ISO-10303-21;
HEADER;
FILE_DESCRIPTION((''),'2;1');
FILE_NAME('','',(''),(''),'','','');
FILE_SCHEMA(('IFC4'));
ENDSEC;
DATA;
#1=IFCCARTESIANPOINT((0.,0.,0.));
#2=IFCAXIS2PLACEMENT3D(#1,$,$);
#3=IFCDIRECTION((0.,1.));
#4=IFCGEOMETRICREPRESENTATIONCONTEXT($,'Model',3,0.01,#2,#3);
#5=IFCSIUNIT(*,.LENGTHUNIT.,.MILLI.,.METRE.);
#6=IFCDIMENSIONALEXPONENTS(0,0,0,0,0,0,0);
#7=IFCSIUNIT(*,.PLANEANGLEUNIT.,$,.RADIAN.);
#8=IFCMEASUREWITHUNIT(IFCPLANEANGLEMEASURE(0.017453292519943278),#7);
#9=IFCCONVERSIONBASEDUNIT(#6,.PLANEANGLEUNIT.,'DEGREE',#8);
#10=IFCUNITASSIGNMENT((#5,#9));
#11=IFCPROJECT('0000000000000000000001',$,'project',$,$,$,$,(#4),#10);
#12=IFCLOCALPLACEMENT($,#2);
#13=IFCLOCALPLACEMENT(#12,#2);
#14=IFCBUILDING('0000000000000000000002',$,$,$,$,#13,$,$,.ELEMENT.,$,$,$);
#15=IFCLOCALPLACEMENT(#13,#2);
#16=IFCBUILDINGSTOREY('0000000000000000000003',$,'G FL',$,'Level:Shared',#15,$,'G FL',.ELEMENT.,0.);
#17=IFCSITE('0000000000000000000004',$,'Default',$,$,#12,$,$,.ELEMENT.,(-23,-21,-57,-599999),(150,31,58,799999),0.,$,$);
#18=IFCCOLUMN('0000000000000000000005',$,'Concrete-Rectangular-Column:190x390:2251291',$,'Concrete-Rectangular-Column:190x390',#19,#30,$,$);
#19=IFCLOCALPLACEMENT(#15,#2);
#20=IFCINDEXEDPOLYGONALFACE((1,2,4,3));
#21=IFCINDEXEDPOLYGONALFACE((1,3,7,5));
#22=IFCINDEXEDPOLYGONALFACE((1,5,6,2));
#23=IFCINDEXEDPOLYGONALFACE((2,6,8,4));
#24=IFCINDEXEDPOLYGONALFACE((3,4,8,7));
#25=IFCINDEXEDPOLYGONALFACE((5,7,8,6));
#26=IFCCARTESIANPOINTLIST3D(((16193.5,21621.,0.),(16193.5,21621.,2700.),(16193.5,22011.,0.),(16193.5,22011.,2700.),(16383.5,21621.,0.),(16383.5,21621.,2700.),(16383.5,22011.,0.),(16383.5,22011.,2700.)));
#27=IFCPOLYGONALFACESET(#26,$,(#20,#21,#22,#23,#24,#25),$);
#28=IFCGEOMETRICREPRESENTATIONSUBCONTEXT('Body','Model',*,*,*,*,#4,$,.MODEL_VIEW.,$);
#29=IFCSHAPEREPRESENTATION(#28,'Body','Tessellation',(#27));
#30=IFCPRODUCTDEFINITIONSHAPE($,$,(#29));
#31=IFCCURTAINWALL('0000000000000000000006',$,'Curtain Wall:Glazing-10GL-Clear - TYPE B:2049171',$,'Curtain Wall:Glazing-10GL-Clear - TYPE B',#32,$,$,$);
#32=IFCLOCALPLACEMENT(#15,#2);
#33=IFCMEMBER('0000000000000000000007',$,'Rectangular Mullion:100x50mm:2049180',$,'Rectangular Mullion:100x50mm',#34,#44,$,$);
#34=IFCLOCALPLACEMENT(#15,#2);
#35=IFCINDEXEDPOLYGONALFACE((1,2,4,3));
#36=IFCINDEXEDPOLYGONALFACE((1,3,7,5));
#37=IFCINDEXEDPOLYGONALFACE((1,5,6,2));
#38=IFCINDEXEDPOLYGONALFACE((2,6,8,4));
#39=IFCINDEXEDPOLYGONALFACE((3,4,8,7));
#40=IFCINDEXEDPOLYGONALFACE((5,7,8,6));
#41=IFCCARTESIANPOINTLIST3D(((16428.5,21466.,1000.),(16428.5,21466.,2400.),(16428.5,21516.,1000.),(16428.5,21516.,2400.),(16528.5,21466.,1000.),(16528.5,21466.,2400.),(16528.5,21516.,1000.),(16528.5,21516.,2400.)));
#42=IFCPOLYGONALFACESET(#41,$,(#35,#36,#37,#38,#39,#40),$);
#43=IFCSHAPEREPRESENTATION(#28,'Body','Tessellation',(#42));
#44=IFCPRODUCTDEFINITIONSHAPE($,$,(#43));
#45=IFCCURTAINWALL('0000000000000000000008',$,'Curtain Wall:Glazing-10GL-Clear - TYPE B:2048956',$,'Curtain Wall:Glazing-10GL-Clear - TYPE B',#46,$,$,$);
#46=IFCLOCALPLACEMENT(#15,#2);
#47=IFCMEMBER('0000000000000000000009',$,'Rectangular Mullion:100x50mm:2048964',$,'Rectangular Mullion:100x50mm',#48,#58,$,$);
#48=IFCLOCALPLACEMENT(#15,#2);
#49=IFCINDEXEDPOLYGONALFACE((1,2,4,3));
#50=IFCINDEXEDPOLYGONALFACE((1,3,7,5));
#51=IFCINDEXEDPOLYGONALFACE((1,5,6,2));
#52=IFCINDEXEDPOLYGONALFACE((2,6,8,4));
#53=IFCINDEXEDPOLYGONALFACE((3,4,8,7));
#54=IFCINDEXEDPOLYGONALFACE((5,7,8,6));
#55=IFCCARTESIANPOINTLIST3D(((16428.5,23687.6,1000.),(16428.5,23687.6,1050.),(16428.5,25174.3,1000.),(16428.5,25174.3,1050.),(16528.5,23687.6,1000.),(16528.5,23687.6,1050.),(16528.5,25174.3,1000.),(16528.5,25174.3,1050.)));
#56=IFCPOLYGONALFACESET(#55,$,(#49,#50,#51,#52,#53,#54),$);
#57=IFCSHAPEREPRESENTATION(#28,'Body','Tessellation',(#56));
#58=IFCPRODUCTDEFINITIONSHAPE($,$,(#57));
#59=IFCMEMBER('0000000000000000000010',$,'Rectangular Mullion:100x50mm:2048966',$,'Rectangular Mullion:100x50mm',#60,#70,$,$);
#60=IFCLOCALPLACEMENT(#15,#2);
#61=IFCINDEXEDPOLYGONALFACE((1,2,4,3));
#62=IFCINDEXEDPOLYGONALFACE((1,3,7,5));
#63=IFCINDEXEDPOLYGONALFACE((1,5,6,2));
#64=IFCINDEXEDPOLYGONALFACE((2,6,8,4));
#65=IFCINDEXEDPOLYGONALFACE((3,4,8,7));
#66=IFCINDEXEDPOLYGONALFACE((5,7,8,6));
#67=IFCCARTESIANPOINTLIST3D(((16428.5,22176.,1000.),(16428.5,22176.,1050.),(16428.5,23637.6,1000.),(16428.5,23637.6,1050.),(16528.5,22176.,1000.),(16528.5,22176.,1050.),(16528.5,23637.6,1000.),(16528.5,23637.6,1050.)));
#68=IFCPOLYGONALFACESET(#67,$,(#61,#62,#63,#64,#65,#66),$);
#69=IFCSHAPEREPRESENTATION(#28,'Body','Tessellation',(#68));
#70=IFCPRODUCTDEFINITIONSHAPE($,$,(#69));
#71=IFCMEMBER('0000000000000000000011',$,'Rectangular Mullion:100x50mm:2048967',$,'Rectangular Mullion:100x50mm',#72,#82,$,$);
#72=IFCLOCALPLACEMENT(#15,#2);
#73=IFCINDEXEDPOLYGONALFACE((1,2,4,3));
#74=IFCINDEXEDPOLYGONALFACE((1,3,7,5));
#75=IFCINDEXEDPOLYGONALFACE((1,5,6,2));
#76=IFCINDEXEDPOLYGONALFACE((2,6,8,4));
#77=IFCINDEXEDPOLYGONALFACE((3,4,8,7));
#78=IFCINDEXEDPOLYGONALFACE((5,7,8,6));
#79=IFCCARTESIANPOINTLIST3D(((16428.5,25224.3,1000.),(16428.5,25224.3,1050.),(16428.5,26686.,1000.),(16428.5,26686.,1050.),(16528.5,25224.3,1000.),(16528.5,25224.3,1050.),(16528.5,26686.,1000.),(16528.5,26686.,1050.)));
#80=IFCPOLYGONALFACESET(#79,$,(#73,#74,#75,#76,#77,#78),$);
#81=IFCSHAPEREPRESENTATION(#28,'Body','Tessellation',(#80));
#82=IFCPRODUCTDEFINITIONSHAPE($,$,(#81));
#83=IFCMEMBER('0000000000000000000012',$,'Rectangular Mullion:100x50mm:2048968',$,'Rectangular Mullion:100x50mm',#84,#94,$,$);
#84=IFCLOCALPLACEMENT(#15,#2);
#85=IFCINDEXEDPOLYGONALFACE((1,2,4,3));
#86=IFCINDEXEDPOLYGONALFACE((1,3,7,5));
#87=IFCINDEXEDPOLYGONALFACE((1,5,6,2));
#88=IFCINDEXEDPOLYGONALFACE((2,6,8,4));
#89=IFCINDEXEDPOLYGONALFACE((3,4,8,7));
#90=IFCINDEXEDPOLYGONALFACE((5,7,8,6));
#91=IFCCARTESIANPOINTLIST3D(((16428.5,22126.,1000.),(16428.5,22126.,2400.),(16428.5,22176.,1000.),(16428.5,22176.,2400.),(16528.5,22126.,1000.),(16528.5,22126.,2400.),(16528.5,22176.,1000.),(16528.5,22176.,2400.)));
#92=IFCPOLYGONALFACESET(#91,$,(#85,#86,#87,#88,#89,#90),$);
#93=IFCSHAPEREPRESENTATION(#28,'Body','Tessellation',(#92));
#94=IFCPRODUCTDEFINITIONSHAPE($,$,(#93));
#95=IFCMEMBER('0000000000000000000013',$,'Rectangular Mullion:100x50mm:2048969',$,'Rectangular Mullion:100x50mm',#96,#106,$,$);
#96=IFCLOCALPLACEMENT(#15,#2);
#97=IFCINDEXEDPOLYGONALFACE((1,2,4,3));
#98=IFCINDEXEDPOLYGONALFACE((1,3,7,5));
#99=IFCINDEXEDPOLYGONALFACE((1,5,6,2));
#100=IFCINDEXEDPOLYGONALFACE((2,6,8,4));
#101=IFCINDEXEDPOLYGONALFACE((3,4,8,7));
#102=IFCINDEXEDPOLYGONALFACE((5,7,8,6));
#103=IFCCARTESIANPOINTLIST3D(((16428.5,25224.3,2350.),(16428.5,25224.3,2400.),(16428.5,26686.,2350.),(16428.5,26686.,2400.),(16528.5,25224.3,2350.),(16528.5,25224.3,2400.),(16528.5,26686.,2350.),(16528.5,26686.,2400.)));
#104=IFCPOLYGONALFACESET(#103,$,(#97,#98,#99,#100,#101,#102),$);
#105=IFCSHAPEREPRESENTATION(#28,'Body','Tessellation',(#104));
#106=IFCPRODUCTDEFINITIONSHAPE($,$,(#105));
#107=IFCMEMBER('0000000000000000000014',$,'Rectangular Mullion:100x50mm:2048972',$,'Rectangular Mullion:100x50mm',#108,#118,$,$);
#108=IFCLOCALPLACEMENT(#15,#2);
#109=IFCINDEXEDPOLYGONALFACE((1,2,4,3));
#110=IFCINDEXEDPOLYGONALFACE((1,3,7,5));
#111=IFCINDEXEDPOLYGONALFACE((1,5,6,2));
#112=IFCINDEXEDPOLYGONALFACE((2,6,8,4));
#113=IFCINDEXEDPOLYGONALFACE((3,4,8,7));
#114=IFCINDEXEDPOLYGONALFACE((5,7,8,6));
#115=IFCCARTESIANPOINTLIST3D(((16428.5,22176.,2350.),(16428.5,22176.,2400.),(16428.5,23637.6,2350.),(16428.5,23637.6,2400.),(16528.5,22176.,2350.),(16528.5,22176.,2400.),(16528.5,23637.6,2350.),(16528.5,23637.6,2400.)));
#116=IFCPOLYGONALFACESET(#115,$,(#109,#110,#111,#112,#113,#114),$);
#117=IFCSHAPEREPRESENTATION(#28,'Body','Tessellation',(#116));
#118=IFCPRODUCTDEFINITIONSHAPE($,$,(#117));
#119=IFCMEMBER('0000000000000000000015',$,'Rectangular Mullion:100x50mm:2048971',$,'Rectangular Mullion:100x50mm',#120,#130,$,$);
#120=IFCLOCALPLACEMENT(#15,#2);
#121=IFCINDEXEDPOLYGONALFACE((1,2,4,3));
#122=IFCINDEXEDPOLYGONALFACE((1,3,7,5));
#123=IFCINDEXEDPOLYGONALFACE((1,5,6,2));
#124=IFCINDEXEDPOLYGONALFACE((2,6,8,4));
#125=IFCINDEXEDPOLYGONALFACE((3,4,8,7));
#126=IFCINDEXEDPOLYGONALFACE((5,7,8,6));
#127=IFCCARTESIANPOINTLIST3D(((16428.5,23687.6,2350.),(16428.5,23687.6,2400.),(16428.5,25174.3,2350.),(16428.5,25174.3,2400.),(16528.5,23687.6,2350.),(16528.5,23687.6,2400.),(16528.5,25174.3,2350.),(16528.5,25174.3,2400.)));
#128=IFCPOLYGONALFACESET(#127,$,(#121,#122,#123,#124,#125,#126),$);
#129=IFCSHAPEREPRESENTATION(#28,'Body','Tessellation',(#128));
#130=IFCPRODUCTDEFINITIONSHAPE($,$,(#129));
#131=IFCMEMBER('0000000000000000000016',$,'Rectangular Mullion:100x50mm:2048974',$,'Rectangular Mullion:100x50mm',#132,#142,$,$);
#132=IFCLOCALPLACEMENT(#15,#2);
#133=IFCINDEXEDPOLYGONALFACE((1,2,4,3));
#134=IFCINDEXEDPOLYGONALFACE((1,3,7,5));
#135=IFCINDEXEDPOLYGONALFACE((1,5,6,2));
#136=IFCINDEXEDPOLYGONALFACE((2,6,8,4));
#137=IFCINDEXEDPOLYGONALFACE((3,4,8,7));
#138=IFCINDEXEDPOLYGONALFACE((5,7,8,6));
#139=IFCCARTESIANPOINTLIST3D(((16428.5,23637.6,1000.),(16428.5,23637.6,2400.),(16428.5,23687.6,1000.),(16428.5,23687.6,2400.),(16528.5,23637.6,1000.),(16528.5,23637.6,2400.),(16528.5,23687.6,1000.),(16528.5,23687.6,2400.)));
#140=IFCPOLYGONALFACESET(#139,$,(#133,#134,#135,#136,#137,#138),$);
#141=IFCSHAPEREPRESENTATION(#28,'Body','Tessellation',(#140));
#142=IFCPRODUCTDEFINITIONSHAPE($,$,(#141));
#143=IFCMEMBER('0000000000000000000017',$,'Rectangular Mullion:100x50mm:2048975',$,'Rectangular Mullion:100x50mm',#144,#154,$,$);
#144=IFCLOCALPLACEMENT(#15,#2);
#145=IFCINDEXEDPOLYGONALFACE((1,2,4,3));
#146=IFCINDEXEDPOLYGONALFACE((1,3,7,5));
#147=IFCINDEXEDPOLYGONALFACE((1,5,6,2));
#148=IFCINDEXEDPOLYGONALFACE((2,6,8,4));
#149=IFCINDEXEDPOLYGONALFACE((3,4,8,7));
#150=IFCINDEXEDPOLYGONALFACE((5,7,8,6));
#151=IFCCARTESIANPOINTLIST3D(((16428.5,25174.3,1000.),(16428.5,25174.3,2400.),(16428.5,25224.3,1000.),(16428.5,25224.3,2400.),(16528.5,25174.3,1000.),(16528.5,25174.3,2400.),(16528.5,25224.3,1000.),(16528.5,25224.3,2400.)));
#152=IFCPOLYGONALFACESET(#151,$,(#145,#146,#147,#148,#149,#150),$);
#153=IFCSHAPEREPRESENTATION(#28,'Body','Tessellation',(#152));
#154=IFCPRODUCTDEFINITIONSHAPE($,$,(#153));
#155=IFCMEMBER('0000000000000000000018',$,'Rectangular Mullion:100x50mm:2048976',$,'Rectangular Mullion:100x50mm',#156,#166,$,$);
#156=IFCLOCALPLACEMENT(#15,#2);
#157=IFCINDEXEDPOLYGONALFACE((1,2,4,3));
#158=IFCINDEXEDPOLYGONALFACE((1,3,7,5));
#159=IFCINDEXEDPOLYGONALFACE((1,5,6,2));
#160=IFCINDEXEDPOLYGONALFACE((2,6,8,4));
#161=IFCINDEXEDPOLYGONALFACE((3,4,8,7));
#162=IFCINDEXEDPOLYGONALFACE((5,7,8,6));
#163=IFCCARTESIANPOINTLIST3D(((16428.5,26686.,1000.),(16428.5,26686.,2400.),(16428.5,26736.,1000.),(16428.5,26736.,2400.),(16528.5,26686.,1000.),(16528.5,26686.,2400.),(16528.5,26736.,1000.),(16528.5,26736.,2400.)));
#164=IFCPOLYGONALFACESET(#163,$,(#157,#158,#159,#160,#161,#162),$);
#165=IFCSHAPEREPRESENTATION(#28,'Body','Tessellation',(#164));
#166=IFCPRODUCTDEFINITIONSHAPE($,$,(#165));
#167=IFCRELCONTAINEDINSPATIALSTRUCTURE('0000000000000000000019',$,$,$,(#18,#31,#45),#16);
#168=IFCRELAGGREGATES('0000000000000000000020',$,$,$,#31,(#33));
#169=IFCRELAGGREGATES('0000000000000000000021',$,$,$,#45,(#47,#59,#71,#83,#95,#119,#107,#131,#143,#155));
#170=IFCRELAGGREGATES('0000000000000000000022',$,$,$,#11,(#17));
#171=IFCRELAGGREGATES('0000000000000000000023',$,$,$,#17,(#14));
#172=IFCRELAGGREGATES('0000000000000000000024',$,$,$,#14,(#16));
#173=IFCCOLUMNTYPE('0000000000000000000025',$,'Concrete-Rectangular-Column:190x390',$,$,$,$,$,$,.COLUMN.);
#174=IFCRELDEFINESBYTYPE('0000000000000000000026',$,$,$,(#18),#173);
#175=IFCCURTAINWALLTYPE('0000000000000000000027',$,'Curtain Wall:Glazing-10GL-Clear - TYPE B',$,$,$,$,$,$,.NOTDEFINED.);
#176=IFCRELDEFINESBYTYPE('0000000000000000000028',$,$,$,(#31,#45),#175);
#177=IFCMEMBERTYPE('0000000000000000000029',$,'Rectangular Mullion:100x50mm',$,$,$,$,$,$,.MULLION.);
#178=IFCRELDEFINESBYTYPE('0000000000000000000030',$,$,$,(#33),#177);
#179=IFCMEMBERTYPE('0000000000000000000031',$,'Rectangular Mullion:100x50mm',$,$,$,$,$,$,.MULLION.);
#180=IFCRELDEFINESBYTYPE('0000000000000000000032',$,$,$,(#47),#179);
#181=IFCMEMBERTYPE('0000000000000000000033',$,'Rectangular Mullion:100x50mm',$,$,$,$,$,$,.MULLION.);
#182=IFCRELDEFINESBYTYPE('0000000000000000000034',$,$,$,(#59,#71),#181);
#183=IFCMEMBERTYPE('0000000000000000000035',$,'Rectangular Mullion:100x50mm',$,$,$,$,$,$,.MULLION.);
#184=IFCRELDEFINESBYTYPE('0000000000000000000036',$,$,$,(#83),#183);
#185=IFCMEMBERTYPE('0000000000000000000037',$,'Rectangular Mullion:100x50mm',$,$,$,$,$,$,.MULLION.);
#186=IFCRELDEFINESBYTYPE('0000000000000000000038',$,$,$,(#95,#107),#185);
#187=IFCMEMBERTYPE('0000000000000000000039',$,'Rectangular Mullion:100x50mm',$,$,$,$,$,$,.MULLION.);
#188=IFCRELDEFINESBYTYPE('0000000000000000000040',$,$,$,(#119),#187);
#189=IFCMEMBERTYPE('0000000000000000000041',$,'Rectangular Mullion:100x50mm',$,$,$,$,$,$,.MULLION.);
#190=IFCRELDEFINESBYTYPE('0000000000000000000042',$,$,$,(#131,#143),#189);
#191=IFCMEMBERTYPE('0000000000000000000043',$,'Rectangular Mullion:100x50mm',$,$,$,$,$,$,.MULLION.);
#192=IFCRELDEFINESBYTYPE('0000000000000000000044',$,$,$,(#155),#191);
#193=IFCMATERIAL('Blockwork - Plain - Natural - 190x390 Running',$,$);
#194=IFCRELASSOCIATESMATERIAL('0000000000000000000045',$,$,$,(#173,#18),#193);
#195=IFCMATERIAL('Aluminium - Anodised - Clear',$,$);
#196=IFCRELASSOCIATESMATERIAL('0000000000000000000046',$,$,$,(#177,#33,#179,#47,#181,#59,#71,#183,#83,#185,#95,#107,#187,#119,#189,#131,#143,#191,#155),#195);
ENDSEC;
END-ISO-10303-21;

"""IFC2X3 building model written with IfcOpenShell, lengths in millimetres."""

from ifc_helpers import new_model, entity, si_unit, converted_unit, direction, frame, frame_2d, origin, origin_2d_with_axis, place, context, subcontext, project, spatial, rectangle, extrude, source, transform, mapped, material, type_object, type_shapes, element, aggregate, save


model = new_model("IFC2X3")

# Units and contexts
model_context = context("Model", 3, precision=0.01, world=origin(), true_north=direction((0.0, 1.0)))
body_context = subcontext(model_context, "Body", "Model", "MODEL_VIEW")
ifc_project = project(units=[si_unit("LENGTHUNIT", "METRE", prefix="MILLI"), converted_unit("PLANEANGLEUNIT", "DEGREE", entity("IfcPlaneAngleMeasure", 0.017453292519943278), si_unit("PLANEANGLEUNIT", "RADIAN"), dimensions=[0, 0, 0, 0, 0, 0, 0])], contexts=[model_context])

# Site, building, storey
site_placement = place(None, origin())
site = spatial("IfcSite", under=ifc_project, at=site_placement, Name="Default", CompositionType="ELEMENT", RefLatitude=(-23, -21, -57, -599999), RefLongitude=(150, 31, 58, 799999), RefElevation=0.0)
building_placement = place(site_placement, origin())
building = spatial("IfcBuilding", under=site, at=building_placement, CompositionType="ELEMENT")
storey_placement = place(building_placement, origin())
storey = spatial("IfcBuildingStorey", under=building, at=storey_placement, Name="G FL", ObjectType="Level:Shared", LongName="G FL", CompositionType="ELEMENT", Elevation=0.0)

# Column
ifc_material_1 = material(Name="Blockwork - Plain - Natural - 190x390 Running")
column_type = type_object("IfcColumnType", Name="Concrete-Rectangular-Column:190x390", PredefinedType="COLUMN", material=ifc_material_1)
shared_shape_1 = source(origin(), body_context, "Body", "SweptSolid", [
    extrude(rectangle(XDim=190.0, YDim=390.0, at=origin_2d_with_axis()), frame((0.0, 0.0, 0.0), z_axis=(0.0, 0.0, 1.0), x_axis=(-1.0, 0.0, 0.0)), (0.0, 0.0, 1.0), 2700.0),
])
type_shapes(column_type, [shared_shape_1])
column_placement = place(storey_placement, frame((16288.5, 21816.0, 0.0)))
element("IfcColumn", 1, at=column_placement, inside=storey, type_object=column_type, material=ifc_material_1, Name="Concrete-Rectangular-Column:190x390:2251291", ObjectType="Concrete-Rectangular-Column:190x390", context=body_context, shape_type="MappedRepresentation", body=[
    mapped(shared_shape_1, transform((0.0, 0.0, 0.0), scale=1.0)),
])

# Curtain wall, member
curtain_wall_type = type_object("IfcCurtainWallType", Name="Curtain Wall:Glazing-10GL-Clear - TYPE B", PredefinedType="NOTDEFINED")
curtain_wall_1_placement = place(storey_placement, origin())
curtain_wall_1 = element("IfcCurtainWall", 2, at=curtain_wall_1_placement, inside=storey, type_object=curtain_wall_type, Name="Curtain Wall:Glazing-10GL-Clear - TYPE B:2049171", ObjectType="Curtain Wall:Glazing-10GL-Clear - TYPE B")
ifc_material_2 = material(Name="Aluminium - Anodised - Clear")
member_type_1 = type_object("IfcMemberType", Name="Rectangular Mullion:100x50mm", PredefinedType="MULLION", material=ifc_material_2)
shared_shape_2 = source(origin(), body_context, "Body", "SweptSolid", [
    extrude(rectangle(XDim=50.0, YDim=100.0, at=origin_2d_with_axis()), frame((-25.0, 0.0, -1400.0), z_axis=(0.0, 0.0, 1.0), x_axis=(-1.0, 0.0, 0.0)), (0.0, 0.0, 1.0), 1400.0),
])
type_shapes(member_type_1, [shared_shape_2])
member_1_placement = place(curtain_wall_1_placement, frame((16478.5, 21516.0, 1000.0), z_axis=(0.0, 0.0, -1.0), x_axis=(0.0, 1.0, 0.0)))
member_1 = element("IfcMember", 3, at=member_1_placement, type_object=member_type_1, material=ifc_material_2, Name="Rectangular Mullion:100x50mm:2049180", ObjectType="Rectangular Mullion:100x50mm", context=body_context, shape_type="MappedRepresentation", body=[
    mapped(shared_shape_2, transform((0.0, 0.0, 0.0), scale=1.0)),
])
aggregate(curtain_wall_1, [member_1])

# Curtain wall, members
curtain_wall_2_placement = place(storey_placement, origin())
curtain_wall_2 = element("IfcCurtainWall", 4, at=curtain_wall_2_placement, inside=storey, type_object=curtain_wall_type, Name="Curtain Wall:Glazing-10GL-Clear - TYPE B:2048956", ObjectType="Curtain Wall:Glazing-10GL-Clear - TYPE B")
member_type_2 = type_object("IfcMemberType", Name="Rectangular Mullion:100x50mm", PredefinedType="MULLION", material=ifc_material_2)
shared_shape_3 = source(origin(), body_context, "Body", "SweptSolid", [
    extrude(rectangle(XDim=50.0, YDim=100.0, at=frame_2d((0.0, 0.0), x_axis=(1.0, 0.0))), frame((-25.0, 0.0, -1486.7), z_axis=(0.0, 0.0, 1.0), x_axis=(-1.0, 0.0, 0.0)), (0.0, 0.0, 1.0), 1486.7),
])
type_shapes(member_type_2, [shared_shape_3])
member_2_placement = place(curtain_wall_2_placement, frame((16478.5, 25174.3, 1000.0), z_axis=(0.0, 1.0, 0.0), x_axis=(0.0, 0.0, -1.0)))
member_2 = element("IfcMember", 5, at=member_2_placement, type_object=member_type_2, material=ifc_material_2, Name="Rectangular Mullion:100x50mm:2048964", ObjectType="Rectangular Mullion:100x50mm", context=body_context, shape_type="MappedRepresentation", body=[
    mapped(shared_shape_3, transform((0.0, 0.0, 0.0), scale=1.0)),
])
member_type_3 = type_object("IfcMemberType", Name="Rectangular Mullion:100x50mm", PredefinedType="MULLION", material=ifc_material_2)
shared_shape_4 = source(origin(), body_context, "Body", "SweptSolid", [
    extrude(rectangle(XDim=50.0, YDim=100.0, at=origin_2d_with_axis()), frame((-25.0, 0.0, -1461.7), z_axis=(0.0, 0.0, 1.0), x_axis=(-1.0, 0.0, 0.0)), (0.0, 0.0, 1.0), 1461.7),
])
type_shapes(member_type_3, [shared_shape_4])
member_3_placement = place(curtain_wall_2_placement, frame((16478.5, 23637.6, 1000.0), z_axis=(0.0, 1.0, 0.0), x_axis=(0.0, 0.0, -1.0)))
member_3 = element("IfcMember", 6, at=member_3_placement, type_object=member_type_3, material=ifc_material_2, Name="Rectangular Mullion:100x50mm:2048966", ObjectType="Rectangular Mullion:100x50mm", context=body_context, shape_type="MappedRepresentation", body=[
    mapped(shared_shape_4, transform((0.0, 0.0, 0.0), scale=1.0)),
])
member_4_placement = place(curtain_wall_2_placement, frame((16478.5, 26686.0, 1000.0), z_axis=(0.0, 1.0, 0.0), x_axis=(0.0, 0.0, -1.0)))
member_4 = element("IfcMember", 7, at=member_4_placement, type_object=member_type_3, material=ifc_material_2, Name="Rectangular Mullion:100x50mm:2048967", ObjectType="Rectangular Mullion:100x50mm", context=body_context, shape_type="MappedRepresentation", body=[
    mapped(shared_shape_4, transform((0.0, 0.0, 0.0), scale=1.0)),
])
member_type_4 = type_object("IfcMemberType", Name="Rectangular Mullion:100x50mm", PredefinedType="MULLION", material=ifc_material_2)
shared_shape_5 = source(origin(), body_context, "Body", "SweptSolid", [
    extrude(rectangle(XDim=50.0, YDim=100.0, at=frame_2d((0.0, 0.0), x_axis=(1.0, 0.0))), frame((-25.0, 0.0, -1400.0), z_axis=(0.0, 0.0, 1.0), x_axis=(-1.0, 0.0, 0.0)), (0.0, 0.0, 1.0), 1400.0),
])
type_shapes(member_type_4, [shared_shape_5])
member_5_placement = place(curtain_wall_2_placement, frame((16478.5, 22126.0, 1000.0), z_axis=(0.0, 0.0, -1.0), x_axis=(0.0, -1.0, 0.0)))
member_5 = element("IfcMember", 8, at=member_5_placement, type_object=member_type_4, material=ifc_material_2, Name="Rectangular Mullion:100x50mm:2048968", ObjectType="Rectangular Mullion:100x50mm", context=body_context, shape_type="MappedRepresentation", body=[
    mapped(shared_shape_5, transform((0.0, 0.0, 0.0), scale=1.0)),
])
member_type_5 = type_object("IfcMemberType", Name="Rectangular Mullion:100x50mm", PredefinedType="MULLION", material=ifc_material_2)
shared_shape_6 = source(origin(), body_context, "Body", "SweptSolid", [
    extrude(rectangle(XDim=50.0, YDim=100.0, at=origin_2d_with_axis()), frame((-25.0, 0.0, -1461.7), z_axis=(0.0, 0.0, 1.0), x_axis=(-1.0, 0.0, 0.0)), (0.0, 0.0, 1.0), 1461.7),
])
type_shapes(member_type_5, [shared_shape_6])
member_6_placement = place(curtain_wall_2_placement, frame((16478.5, 25224.3, 2400.0), z_axis=(0.0, -1.0, 0.0), x_axis=(0.0, 0.0, 1.0)))
member_6 = element("IfcMember", 9, at=member_6_placement, type_object=member_type_5, material=ifc_material_2, Name="Rectangular Mullion:100x50mm:2048969", ObjectType="Rectangular Mullion:100x50mm", context=body_context, shape_type="MappedRepresentation", body=[
    mapped(shared_shape_6, transform((0.0, 0.0, 0.0), scale=1.0)),
])
member_7_placement = place(curtain_wall_2_placement, frame((16478.5, 22176.0, 2400.0), z_axis=(0.0, -1.0, 0.0), x_axis=(0.0, 0.0, 1.0)))
member_7 = element("IfcMember", 10, at=member_7_placement, type_object=member_type_5, material=ifc_material_2, Name="Rectangular Mullion:100x50mm:2048972", ObjectType="Rectangular Mullion:100x50mm", context=body_context, shape_type="MappedRepresentation", body=[
    mapped(shared_shape_6, transform((0.0, 0.0, 0.0), scale=1.0)),
])
member_type_6 = type_object("IfcMemberType", Name="Rectangular Mullion:100x50mm", PredefinedType="MULLION", material=ifc_material_2)
shared_shape_7 = source(origin(), body_context, "Body", "SweptSolid", [
    extrude(rectangle(XDim=50.0, YDim=100.0, at=frame_2d((0.0, 0.0), x_axis=(1.0, 0.0))), frame((-25.0, 0.0, -1486.7), z_axis=(0.0, 0.0, 1.0), x_axis=(-1.0, 0.0, 0.0)), (0.0, 0.0, 1.0), 1486.7),
])
type_shapes(member_type_6, [shared_shape_7])
member_8_placement = place(curtain_wall_2_placement, frame((16478.5, 23687.6, 2400.0), z_axis=(0.0, -1.0, 0.0), x_axis=(0.0, 0.0, 1.0)))
member_8 = element("IfcMember", 11, at=member_8_placement, type_object=member_type_6, material=ifc_material_2, Name="Rectangular Mullion:100x50mm:2048971", ObjectType="Rectangular Mullion:100x50mm", context=body_context, shape_type="MappedRepresentation", body=[
    mapped(shared_shape_7, transform((0.0, 0.0, 0.0), scale=1.0)),
])
member_type_7 = type_object("IfcMemberType", Name="Rectangular Mullion:100x50mm", PredefinedType="MULLION", material=ifc_material_2)
shared_shape_8 = source(origin(), body_context, "Body", "SweptSolid", [
    extrude(rectangle(XDim=50.0, YDim=100.0, at=frame_2d((0.0, 0.0), x_axis=(1.0, 0.0))), frame((0.0, 0.0, -1400.0), z_axis=(0.0, 0.0, 1.0), x_axis=(-1.0, 0.0, 0.0)), (0.0, 0.0, 1.0), 1400.0),
])
type_shapes(member_type_7, [shared_shape_8])
member_9_placement = place(curtain_wall_2_placement, frame((16478.5, 23662.6, 1000.0), z_axis=(0.0, 0.0, -1.0), x_axis=(0.0, -1.0, 0.0)))
member_9 = element("IfcMember", 12, at=member_9_placement, type_object=member_type_7, material=ifc_material_2, Name="Rectangular Mullion:100x50mm:2048974", ObjectType="Rectangular Mullion:100x50mm", context=body_context, shape_type="MappedRepresentation", body=[
    mapped(shared_shape_8, transform((0.0, 0.0, 0.0), scale=1.0)),
])
member_10_placement = place(curtain_wall_2_placement, frame((16478.5, 25199.3, 1000.0), z_axis=(0.0, 0.0, -1.0), x_axis=(0.0, -1.0, 0.0)))
member_10 = element("IfcMember", 13, at=member_10_placement, type_object=member_type_7, material=ifc_material_2, Name="Rectangular Mullion:100x50mm:2048975", ObjectType="Rectangular Mullion:100x50mm", context=body_context, shape_type="MappedRepresentation", body=[
    mapped(shared_shape_8, transform((0.0, 0.0, 0.0), scale=1.0)),
])
member_type_8 = type_object("IfcMemberType", Name="Rectangular Mullion:100x50mm", PredefinedType="MULLION", material=ifc_material_2)
shared_shape_9 = source(origin(), body_context, "Body", "SweptSolid", [
    extrude(rectangle(XDim=50.0, YDim=100.0, at=origin_2d_with_axis()), frame((-25.0, 0.0, -1400.0), z_axis=(0.0, 0.0, 1.0), x_axis=(-1.0, 0.0, 0.0)), (0.0, 0.0, 1.0), 1400.0),
])
type_shapes(member_type_8, [shared_shape_9])
member_11_placement = place(curtain_wall_2_placement, frame((16478.5, 26736.0, 2400.0), z_axis=(0.0, 0.0, 1.0), x_axis=(0.0, 1.0, 0.0)))
member_11 = element("IfcMember", 14, at=member_11_placement, type_object=member_type_8, material=ifc_material_2, Name="Rectangular Mullion:100x50mm:2048976", ObjectType="Rectangular Mullion:100x50mm", context=body_context, shape_type="MappedRepresentation", body=[
    mapped(shared_shape_9, transform((0.0, 0.0, 0.0), scale=1.0)),
])

aggregate(curtain_wall_2, [member_2, member_3, member_4, member_5, member_6, member_8, member_7, member_9, member_10, member_11])

save(model, "model.ifc")
